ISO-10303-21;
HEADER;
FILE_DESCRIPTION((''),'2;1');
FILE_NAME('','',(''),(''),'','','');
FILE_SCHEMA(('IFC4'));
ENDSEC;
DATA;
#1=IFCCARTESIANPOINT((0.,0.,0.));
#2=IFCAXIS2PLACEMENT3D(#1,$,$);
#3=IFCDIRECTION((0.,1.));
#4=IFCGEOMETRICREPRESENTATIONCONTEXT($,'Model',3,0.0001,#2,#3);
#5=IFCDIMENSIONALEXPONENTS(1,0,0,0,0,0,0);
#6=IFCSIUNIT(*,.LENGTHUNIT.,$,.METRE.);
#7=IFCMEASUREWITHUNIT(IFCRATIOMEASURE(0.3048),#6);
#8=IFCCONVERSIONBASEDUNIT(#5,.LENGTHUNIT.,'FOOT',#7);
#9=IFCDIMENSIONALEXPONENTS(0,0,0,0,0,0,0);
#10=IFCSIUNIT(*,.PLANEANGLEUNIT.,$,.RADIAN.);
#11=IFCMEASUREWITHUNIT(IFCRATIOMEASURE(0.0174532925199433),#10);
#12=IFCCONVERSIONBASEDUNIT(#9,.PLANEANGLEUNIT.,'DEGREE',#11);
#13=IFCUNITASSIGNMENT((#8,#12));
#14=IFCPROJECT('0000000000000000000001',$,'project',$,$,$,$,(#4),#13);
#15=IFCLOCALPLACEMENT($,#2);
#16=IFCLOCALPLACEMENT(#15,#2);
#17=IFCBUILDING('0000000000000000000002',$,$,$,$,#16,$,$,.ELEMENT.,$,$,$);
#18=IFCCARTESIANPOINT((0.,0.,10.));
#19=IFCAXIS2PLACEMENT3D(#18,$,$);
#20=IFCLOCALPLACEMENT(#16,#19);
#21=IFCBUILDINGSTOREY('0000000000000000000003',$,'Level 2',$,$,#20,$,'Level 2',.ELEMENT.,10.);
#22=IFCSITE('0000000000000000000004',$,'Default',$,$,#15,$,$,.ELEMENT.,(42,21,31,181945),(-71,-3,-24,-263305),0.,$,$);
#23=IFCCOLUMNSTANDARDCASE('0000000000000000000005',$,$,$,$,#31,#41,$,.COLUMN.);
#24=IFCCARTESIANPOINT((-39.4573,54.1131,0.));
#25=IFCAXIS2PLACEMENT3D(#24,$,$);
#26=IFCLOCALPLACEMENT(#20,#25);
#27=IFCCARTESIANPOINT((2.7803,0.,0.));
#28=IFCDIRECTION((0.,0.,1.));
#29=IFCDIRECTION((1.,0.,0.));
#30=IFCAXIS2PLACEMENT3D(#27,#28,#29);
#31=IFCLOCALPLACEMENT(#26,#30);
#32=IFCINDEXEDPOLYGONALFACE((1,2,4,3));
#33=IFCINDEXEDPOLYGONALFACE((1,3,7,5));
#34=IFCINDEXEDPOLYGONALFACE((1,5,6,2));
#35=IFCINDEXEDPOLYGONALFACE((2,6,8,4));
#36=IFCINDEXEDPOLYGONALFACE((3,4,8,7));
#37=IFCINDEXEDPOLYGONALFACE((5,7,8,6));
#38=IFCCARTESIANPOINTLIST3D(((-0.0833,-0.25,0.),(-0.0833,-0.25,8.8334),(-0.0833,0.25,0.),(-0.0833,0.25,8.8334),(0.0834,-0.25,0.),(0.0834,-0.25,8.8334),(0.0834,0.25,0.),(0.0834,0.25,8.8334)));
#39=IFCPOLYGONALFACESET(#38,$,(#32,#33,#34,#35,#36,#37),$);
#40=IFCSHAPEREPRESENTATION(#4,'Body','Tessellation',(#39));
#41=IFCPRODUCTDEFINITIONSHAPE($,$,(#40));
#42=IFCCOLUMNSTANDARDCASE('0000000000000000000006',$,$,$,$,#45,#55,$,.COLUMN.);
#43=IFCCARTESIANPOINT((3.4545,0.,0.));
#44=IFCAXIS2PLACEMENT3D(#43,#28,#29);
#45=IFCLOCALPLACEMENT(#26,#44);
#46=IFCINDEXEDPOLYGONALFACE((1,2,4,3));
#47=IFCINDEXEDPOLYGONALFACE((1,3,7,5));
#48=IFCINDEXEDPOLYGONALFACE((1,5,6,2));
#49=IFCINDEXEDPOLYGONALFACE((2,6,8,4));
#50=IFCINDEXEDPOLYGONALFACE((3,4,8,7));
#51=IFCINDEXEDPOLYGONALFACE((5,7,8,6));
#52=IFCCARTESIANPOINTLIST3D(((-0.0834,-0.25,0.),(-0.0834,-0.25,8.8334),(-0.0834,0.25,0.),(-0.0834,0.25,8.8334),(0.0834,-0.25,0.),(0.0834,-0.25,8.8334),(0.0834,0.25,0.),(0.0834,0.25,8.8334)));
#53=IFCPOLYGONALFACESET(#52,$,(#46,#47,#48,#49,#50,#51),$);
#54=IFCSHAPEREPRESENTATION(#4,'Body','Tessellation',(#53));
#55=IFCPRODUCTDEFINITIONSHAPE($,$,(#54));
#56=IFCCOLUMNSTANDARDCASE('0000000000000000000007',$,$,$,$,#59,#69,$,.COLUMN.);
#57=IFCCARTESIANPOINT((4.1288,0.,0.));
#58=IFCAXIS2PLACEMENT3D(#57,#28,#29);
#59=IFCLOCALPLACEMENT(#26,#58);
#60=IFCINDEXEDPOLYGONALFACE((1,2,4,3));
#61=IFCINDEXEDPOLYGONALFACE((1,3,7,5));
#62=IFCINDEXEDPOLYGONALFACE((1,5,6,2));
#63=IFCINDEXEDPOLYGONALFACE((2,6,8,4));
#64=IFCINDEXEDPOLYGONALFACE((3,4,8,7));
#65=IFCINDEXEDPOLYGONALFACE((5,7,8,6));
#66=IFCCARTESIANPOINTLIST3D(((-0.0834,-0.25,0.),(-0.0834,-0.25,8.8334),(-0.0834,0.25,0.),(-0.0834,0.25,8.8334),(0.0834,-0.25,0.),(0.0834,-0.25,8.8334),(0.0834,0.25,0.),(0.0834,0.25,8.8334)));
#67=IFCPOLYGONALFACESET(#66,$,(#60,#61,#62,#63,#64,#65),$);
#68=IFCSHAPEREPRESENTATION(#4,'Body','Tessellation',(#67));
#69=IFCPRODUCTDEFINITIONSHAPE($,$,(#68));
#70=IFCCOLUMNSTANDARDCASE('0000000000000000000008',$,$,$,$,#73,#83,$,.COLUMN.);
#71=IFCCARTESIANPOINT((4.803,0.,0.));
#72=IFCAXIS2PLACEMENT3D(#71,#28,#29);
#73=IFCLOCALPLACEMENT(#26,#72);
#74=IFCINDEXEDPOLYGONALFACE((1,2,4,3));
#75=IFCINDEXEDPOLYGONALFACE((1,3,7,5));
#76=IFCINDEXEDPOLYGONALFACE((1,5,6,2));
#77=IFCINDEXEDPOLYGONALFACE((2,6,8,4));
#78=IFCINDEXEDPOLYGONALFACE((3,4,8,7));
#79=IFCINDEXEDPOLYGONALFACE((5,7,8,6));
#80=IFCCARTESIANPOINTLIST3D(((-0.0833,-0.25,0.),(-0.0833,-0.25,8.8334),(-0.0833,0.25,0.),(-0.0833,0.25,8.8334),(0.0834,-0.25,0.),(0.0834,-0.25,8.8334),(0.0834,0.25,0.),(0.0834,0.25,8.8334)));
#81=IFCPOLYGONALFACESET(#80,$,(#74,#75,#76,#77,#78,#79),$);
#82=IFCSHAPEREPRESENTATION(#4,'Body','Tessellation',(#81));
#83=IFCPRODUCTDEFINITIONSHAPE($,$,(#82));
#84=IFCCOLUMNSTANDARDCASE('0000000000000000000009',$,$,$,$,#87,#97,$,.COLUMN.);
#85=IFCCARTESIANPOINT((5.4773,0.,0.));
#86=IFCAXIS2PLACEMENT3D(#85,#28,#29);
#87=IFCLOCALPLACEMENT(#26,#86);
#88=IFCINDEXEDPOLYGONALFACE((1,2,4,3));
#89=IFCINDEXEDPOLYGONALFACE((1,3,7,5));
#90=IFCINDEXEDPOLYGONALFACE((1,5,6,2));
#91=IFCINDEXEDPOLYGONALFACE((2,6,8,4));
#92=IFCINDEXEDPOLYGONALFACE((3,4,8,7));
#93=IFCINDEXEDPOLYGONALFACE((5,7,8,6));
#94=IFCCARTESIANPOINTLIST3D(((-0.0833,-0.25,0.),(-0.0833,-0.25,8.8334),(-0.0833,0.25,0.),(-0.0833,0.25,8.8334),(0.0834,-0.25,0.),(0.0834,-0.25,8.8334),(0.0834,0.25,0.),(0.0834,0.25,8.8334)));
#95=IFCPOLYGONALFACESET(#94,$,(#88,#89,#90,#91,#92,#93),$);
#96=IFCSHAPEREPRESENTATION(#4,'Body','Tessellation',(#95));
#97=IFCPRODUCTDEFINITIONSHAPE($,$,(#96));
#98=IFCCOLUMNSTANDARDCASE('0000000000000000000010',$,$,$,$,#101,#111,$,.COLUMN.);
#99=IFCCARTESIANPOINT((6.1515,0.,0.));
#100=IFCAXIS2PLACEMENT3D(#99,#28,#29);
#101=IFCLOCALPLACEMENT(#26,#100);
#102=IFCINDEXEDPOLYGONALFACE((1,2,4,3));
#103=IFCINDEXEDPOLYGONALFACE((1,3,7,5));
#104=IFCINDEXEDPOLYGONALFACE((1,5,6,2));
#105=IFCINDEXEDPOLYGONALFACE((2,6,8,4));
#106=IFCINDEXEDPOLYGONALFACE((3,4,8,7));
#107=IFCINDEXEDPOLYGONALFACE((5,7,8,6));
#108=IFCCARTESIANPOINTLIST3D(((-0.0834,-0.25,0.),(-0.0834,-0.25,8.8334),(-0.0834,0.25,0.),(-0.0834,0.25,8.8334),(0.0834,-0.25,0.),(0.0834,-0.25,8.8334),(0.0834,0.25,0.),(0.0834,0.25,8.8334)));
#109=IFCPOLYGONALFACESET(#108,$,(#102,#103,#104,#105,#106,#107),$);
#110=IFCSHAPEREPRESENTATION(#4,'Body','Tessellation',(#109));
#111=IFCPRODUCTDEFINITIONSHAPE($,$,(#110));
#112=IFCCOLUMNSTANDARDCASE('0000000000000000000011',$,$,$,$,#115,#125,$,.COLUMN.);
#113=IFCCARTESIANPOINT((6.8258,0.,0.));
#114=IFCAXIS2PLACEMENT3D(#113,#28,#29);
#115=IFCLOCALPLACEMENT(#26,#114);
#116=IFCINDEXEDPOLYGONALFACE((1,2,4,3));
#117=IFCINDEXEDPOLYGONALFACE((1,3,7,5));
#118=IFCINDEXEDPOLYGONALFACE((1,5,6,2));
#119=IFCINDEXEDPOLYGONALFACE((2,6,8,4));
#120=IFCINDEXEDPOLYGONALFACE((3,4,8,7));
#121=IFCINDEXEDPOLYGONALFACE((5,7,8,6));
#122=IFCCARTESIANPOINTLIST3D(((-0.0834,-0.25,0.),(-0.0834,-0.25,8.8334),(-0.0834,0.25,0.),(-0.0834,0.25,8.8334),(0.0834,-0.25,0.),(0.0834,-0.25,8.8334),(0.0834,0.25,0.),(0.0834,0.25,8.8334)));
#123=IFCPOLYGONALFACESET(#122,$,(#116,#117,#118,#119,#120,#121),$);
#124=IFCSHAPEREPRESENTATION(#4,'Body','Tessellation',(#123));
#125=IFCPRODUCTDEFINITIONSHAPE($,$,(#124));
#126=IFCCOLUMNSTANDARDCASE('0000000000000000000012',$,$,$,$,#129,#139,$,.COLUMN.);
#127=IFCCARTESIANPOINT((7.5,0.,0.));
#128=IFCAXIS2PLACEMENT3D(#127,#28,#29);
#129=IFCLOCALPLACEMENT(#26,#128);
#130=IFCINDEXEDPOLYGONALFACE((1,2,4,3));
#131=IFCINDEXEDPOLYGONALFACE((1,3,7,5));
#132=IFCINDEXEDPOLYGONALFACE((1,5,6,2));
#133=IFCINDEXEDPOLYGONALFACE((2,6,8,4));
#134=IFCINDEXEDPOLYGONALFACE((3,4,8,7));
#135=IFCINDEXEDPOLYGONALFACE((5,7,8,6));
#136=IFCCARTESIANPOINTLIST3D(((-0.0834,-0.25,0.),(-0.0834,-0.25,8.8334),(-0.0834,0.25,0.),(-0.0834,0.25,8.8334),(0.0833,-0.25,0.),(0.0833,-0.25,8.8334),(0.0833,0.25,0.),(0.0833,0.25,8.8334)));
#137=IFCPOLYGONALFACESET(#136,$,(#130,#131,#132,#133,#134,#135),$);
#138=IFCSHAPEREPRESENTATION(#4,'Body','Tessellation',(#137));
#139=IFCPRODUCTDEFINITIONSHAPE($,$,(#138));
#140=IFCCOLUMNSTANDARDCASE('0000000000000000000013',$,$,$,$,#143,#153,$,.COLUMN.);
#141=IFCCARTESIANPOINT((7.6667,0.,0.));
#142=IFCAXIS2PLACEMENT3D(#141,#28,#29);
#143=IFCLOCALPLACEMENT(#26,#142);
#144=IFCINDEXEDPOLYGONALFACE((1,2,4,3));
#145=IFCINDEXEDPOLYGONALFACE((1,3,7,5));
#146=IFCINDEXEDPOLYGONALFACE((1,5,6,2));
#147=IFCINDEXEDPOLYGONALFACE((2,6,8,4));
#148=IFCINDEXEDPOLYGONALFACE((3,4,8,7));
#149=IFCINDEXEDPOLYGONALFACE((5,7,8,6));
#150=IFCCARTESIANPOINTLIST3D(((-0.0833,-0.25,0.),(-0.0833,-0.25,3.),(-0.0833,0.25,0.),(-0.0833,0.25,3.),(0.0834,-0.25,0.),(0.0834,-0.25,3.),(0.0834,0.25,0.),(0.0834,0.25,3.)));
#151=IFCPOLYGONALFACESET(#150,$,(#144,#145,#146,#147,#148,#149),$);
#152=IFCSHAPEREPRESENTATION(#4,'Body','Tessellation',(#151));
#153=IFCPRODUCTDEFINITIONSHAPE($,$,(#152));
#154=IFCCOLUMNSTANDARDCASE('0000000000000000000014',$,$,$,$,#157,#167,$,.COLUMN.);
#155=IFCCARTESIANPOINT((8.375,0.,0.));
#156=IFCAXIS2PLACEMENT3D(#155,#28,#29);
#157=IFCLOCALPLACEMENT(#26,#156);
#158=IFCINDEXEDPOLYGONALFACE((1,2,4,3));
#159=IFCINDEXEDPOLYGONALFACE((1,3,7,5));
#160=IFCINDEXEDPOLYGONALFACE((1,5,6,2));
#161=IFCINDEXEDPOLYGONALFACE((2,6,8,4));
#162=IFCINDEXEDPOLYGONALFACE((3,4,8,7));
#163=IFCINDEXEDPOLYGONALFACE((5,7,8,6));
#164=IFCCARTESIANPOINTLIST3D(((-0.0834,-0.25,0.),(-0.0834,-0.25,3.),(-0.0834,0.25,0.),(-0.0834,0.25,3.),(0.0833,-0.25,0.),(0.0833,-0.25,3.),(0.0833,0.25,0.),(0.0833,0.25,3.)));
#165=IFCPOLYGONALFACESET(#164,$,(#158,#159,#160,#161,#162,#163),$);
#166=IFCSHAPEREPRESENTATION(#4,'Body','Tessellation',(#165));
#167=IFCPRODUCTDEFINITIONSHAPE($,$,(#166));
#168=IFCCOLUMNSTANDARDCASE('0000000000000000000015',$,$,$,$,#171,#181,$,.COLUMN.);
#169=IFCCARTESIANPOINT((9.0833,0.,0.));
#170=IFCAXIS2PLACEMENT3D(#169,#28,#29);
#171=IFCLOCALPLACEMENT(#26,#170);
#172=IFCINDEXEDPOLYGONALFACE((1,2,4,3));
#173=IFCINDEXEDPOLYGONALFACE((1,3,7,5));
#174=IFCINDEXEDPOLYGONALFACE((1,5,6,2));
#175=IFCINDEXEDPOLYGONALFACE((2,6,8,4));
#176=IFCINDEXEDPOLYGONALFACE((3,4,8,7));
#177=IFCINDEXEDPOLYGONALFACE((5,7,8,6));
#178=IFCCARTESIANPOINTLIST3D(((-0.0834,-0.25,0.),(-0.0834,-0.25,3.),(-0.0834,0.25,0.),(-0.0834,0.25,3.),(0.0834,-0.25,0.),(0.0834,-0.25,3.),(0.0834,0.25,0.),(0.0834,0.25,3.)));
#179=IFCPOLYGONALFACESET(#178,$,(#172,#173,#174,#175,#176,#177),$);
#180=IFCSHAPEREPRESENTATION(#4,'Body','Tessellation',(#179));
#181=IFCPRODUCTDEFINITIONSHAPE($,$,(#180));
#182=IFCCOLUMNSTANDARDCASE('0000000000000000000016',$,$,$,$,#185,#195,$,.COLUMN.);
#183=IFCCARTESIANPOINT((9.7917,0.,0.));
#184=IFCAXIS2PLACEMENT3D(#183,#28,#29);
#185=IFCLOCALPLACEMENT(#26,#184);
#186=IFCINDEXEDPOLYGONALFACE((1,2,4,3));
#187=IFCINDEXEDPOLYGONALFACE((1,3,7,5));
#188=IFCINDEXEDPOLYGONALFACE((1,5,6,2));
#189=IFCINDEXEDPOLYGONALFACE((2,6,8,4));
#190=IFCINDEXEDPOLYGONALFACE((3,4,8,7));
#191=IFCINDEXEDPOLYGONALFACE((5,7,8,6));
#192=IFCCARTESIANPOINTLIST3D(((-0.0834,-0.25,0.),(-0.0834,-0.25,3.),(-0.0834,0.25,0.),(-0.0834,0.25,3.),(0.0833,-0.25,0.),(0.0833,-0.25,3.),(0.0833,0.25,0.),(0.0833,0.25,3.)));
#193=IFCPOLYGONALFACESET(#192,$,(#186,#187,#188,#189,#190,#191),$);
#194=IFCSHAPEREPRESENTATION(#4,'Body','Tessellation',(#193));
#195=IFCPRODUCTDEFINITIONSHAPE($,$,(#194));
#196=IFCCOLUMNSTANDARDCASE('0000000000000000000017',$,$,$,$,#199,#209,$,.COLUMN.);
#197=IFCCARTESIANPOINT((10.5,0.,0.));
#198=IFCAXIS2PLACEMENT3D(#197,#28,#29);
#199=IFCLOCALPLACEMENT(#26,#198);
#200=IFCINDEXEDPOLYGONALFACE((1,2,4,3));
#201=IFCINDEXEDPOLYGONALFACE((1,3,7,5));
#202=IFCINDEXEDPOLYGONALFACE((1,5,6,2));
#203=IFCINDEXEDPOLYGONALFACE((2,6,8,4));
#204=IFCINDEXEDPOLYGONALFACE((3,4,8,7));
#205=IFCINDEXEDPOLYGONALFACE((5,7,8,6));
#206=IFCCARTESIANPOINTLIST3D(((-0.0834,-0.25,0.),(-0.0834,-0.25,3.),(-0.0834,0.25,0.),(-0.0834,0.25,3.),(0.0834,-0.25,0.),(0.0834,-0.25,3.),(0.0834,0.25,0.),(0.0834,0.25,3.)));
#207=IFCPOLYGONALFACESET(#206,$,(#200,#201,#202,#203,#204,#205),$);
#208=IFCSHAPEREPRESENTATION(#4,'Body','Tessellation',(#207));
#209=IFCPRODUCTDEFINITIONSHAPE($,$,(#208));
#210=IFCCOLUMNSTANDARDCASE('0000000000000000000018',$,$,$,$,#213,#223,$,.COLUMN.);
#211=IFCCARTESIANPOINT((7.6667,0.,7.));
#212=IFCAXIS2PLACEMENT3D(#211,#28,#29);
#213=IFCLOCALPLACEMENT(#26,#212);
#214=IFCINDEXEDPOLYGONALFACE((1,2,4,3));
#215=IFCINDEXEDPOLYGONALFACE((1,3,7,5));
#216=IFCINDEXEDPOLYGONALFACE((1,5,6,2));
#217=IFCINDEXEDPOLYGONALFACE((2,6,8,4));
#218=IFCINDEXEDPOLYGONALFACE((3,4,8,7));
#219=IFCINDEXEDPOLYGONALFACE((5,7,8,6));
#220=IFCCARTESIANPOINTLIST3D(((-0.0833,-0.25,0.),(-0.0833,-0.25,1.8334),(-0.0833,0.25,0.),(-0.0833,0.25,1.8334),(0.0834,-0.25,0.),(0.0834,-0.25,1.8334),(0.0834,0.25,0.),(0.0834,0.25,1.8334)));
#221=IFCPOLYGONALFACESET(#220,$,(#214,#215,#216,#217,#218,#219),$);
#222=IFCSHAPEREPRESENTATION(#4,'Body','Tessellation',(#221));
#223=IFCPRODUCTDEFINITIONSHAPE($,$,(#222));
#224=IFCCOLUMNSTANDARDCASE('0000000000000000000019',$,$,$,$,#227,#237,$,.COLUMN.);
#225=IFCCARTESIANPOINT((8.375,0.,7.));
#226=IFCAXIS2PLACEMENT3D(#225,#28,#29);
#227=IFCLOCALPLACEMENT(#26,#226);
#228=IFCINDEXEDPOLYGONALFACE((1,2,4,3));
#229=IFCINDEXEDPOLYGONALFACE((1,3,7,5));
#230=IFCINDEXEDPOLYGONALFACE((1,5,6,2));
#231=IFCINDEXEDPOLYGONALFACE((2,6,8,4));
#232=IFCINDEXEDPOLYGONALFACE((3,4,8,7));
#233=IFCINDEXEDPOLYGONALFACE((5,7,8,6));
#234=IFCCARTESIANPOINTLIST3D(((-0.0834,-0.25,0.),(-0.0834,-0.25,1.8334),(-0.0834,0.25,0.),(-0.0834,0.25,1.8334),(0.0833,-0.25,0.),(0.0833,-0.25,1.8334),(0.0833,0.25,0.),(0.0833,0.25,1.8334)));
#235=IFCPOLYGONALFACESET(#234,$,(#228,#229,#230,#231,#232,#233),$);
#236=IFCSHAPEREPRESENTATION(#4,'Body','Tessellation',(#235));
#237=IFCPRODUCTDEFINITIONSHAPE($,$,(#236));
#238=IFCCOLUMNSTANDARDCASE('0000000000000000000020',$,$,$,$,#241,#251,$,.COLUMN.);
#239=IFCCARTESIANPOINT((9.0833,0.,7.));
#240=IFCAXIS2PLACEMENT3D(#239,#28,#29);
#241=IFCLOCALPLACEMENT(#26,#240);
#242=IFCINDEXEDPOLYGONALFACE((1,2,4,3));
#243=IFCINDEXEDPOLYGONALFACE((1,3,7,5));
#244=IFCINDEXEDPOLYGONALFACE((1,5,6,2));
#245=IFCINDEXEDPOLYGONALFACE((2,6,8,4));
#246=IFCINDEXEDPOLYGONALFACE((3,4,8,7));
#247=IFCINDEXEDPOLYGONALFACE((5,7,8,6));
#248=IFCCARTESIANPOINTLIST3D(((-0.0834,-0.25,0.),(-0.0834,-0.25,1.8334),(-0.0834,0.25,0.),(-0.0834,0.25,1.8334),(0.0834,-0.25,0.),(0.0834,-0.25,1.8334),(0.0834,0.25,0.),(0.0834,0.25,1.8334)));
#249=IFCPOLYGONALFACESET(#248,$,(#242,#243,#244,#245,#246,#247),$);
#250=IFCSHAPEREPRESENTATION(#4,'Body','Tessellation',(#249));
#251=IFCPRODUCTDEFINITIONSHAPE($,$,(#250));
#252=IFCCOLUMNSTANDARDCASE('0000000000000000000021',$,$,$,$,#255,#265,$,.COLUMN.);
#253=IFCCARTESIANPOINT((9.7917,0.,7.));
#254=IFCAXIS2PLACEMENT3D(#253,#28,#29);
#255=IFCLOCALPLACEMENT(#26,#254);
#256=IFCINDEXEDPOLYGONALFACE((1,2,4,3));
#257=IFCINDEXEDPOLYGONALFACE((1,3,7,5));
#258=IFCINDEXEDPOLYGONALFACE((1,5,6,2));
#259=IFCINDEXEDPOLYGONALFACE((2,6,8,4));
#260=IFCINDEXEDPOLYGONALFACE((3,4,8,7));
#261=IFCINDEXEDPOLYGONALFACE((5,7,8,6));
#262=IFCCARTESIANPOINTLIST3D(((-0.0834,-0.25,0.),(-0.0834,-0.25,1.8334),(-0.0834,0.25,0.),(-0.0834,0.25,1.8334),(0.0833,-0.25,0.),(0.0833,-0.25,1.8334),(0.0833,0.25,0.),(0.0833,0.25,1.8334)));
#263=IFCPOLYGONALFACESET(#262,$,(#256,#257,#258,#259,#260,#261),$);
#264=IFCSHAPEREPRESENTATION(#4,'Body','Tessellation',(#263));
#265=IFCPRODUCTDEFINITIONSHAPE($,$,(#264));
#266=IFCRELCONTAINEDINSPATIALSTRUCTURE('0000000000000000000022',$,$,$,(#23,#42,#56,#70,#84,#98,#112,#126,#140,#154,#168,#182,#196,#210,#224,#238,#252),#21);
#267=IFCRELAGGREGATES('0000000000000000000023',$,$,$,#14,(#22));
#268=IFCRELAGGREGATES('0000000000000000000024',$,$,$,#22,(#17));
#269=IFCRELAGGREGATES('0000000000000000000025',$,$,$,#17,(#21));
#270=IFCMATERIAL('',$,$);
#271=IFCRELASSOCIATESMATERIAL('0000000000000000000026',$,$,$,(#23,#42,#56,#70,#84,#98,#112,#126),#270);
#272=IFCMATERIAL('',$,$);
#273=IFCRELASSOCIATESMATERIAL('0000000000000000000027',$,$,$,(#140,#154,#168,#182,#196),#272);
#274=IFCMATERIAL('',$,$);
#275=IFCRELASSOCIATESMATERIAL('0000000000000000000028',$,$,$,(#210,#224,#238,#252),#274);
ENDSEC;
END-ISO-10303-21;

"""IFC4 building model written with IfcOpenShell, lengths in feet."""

from ifc_helpers import new_model, entity, si_unit, converted_unit, direction, frame, origin, place, context, project, spatial, rectangle, extrude, material, element, save


model = new_model("IFC4")

# Units and contexts
model_context = context("Model", 3, precision=0.0001, world=origin(), true_north=direction((0.0, 1.0)))
ifc_project = project(units=[converted_unit("LENGTHUNIT", "FOOT", entity("IfcRatioMeasure", 0.3048), si_unit("LENGTHUNIT", "METRE"), dimensions=[1, 0, 0, 0, 0, 0, 0]), converted_unit("PLANEANGLEUNIT", "DEGREE", entity("IfcRatioMeasure", 0.0174532925199433), si_unit("PLANEANGLEUNIT", "RADIAN"), dimensions=[0, 0, 0, 0, 0, 0, 0])], contexts=[model_context])

# Site, building, storey
site_placement = place(None, origin())
site = spatial("IfcSite", under=ifc_project, at=site_placement, Name="Default", CompositionType="ELEMENT", RefLatitude=(42, 21, 31, 181945), RefLongitude=(-71, -3, -24, -263305), RefElevation=0.0)
building_placement = place(site_placement, origin())
building = spatial("IfcBuilding", under=site, at=building_placement, CompositionType="ELEMENT")
storey_placement = place(building_placement, frame((0.0, 0.0, 10.0)))
storey = spatial("IfcBuildingStorey", under=building, at=storey_placement, Name="Level 2", LongName="Level 2", CompositionType="ELEMENT", Elevation=10.0)

# Columns
ifc_material_1 = material(Name="")
placement_1 = place(storey_placement, frame((-39.4573, 54.1131, 0.0)))
for number, where, z_axis, x_axis in (
    (1, (2.7803, 0.0, 0.0), (0.0, 0.0, 1.0), (1.0, 0.0, 0.0)),
    (2, (3.4545, 0.0, 0.0), (0.0, 0.0, 1.0), (1.0, 0.0, 0.0)),
    (3, (4.1288, 0.0, 0.0), (0.0, 0.0, 1.0), (1.0, 0.0, 0.0)),
    (4, (4.803, 0.0, 0.0), (0.0, 0.0, 1.0), (1.0, 0.0, 0.0)),
    (5, (5.4773, 0.0, 0.0), (0.0, 0.0, 1.0), (1.0, 0.0, 0.0)),
    (6, (6.1515, 0.0, 0.0), (0.0, 0.0, 1.0), (1.0, 0.0, 0.0)),
    (7, (6.8258, 0.0, 0.0), (0.0, 0.0, 1.0), (1.0, 0.0, 0.0)),
    (8, (7.5, 0.0, 0.0), (0.0, 0.0, 1.0), (1.0, 0.0, 0.0)),
):
    element("IfcColumnStandardCase", number, at=place(placement_1, frame(where, z_axis=z_axis, x_axis=x_axis)), inside=storey, material=ifc_material_1, PredefinedType="COLUMN", context=model_context, shape_type="SweptSolid", body=[
        extrude(rectangle(XDim=0.1667, YDim=0.5), origin(), (0.0, 0.0, 1.0), 8.8334),
    ])
ifc_material_2 = material(Name="")
for number, where, z_axis, x_axis in (
    (9, (7.6667, 0.0, 0.0), (0.0, 0.0, 1.0), (1.0, 0.0, 0.0)),
    (10, (8.375, 0.0, 0.0), (0.0, 0.0, 1.0), (1.0, 0.0, 0.0)),
    (11, (9.0833, 0.0, 0.0), (0.0, 0.0, 1.0), (1.0, 0.0, 0.0)),
    (12, (9.7917, 0.0, 0.0), (0.0, 0.0, 1.0), (1.0, 0.0, 0.0)),
    (13, (10.5, 0.0, 0.0), (0.0, 0.0, 1.0), (1.0, 0.0, 0.0)),
):
    element("IfcColumnStandardCase", number, at=place(placement_1, frame(where, z_axis=z_axis, x_axis=x_axis)), inside=storey, material=ifc_material_2, PredefinedType="COLUMN", context=model_context, shape_type="SweptSolid", body=[
        extrude(rectangle(XDim=0.1667, YDim=0.5), origin(), (0.0, 0.0, 1.0), 3.0),
    ])
ifc_material_3 = material(Name="")
for number, where, z_axis, x_axis in (
    (14, (7.6667, 0.0, 7.0), (0.0, 0.0, 1.0), (1.0, 0.0, 0.0)),
    (15, (8.375, 0.0, 7.0), (0.0, 0.0, 1.0), (1.0, 0.0, 0.0)),
    (16, (9.0833, 0.0, 7.0), (0.0, 0.0, 1.0), (1.0, 0.0, 0.0)),
    (17, (9.7917, 0.0, 7.0), (0.0, 0.0, 1.0), (1.0, 0.0, 0.0)),
):
    element("IfcColumnStandardCase", number, at=place(placement_1, frame(where, z_axis=z_axis, x_axis=x_axis)), inside=storey, material=ifc_material_3, PredefinedType="COLUMN", context=model_context, shape_type="SweptSolid", body=[
        extrude(rectangle(XDim=0.1667, YDim=0.5), origin(), (0.0, 0.0, 1.0), 1.8334),
    ])

save(model, "model.ifc")
